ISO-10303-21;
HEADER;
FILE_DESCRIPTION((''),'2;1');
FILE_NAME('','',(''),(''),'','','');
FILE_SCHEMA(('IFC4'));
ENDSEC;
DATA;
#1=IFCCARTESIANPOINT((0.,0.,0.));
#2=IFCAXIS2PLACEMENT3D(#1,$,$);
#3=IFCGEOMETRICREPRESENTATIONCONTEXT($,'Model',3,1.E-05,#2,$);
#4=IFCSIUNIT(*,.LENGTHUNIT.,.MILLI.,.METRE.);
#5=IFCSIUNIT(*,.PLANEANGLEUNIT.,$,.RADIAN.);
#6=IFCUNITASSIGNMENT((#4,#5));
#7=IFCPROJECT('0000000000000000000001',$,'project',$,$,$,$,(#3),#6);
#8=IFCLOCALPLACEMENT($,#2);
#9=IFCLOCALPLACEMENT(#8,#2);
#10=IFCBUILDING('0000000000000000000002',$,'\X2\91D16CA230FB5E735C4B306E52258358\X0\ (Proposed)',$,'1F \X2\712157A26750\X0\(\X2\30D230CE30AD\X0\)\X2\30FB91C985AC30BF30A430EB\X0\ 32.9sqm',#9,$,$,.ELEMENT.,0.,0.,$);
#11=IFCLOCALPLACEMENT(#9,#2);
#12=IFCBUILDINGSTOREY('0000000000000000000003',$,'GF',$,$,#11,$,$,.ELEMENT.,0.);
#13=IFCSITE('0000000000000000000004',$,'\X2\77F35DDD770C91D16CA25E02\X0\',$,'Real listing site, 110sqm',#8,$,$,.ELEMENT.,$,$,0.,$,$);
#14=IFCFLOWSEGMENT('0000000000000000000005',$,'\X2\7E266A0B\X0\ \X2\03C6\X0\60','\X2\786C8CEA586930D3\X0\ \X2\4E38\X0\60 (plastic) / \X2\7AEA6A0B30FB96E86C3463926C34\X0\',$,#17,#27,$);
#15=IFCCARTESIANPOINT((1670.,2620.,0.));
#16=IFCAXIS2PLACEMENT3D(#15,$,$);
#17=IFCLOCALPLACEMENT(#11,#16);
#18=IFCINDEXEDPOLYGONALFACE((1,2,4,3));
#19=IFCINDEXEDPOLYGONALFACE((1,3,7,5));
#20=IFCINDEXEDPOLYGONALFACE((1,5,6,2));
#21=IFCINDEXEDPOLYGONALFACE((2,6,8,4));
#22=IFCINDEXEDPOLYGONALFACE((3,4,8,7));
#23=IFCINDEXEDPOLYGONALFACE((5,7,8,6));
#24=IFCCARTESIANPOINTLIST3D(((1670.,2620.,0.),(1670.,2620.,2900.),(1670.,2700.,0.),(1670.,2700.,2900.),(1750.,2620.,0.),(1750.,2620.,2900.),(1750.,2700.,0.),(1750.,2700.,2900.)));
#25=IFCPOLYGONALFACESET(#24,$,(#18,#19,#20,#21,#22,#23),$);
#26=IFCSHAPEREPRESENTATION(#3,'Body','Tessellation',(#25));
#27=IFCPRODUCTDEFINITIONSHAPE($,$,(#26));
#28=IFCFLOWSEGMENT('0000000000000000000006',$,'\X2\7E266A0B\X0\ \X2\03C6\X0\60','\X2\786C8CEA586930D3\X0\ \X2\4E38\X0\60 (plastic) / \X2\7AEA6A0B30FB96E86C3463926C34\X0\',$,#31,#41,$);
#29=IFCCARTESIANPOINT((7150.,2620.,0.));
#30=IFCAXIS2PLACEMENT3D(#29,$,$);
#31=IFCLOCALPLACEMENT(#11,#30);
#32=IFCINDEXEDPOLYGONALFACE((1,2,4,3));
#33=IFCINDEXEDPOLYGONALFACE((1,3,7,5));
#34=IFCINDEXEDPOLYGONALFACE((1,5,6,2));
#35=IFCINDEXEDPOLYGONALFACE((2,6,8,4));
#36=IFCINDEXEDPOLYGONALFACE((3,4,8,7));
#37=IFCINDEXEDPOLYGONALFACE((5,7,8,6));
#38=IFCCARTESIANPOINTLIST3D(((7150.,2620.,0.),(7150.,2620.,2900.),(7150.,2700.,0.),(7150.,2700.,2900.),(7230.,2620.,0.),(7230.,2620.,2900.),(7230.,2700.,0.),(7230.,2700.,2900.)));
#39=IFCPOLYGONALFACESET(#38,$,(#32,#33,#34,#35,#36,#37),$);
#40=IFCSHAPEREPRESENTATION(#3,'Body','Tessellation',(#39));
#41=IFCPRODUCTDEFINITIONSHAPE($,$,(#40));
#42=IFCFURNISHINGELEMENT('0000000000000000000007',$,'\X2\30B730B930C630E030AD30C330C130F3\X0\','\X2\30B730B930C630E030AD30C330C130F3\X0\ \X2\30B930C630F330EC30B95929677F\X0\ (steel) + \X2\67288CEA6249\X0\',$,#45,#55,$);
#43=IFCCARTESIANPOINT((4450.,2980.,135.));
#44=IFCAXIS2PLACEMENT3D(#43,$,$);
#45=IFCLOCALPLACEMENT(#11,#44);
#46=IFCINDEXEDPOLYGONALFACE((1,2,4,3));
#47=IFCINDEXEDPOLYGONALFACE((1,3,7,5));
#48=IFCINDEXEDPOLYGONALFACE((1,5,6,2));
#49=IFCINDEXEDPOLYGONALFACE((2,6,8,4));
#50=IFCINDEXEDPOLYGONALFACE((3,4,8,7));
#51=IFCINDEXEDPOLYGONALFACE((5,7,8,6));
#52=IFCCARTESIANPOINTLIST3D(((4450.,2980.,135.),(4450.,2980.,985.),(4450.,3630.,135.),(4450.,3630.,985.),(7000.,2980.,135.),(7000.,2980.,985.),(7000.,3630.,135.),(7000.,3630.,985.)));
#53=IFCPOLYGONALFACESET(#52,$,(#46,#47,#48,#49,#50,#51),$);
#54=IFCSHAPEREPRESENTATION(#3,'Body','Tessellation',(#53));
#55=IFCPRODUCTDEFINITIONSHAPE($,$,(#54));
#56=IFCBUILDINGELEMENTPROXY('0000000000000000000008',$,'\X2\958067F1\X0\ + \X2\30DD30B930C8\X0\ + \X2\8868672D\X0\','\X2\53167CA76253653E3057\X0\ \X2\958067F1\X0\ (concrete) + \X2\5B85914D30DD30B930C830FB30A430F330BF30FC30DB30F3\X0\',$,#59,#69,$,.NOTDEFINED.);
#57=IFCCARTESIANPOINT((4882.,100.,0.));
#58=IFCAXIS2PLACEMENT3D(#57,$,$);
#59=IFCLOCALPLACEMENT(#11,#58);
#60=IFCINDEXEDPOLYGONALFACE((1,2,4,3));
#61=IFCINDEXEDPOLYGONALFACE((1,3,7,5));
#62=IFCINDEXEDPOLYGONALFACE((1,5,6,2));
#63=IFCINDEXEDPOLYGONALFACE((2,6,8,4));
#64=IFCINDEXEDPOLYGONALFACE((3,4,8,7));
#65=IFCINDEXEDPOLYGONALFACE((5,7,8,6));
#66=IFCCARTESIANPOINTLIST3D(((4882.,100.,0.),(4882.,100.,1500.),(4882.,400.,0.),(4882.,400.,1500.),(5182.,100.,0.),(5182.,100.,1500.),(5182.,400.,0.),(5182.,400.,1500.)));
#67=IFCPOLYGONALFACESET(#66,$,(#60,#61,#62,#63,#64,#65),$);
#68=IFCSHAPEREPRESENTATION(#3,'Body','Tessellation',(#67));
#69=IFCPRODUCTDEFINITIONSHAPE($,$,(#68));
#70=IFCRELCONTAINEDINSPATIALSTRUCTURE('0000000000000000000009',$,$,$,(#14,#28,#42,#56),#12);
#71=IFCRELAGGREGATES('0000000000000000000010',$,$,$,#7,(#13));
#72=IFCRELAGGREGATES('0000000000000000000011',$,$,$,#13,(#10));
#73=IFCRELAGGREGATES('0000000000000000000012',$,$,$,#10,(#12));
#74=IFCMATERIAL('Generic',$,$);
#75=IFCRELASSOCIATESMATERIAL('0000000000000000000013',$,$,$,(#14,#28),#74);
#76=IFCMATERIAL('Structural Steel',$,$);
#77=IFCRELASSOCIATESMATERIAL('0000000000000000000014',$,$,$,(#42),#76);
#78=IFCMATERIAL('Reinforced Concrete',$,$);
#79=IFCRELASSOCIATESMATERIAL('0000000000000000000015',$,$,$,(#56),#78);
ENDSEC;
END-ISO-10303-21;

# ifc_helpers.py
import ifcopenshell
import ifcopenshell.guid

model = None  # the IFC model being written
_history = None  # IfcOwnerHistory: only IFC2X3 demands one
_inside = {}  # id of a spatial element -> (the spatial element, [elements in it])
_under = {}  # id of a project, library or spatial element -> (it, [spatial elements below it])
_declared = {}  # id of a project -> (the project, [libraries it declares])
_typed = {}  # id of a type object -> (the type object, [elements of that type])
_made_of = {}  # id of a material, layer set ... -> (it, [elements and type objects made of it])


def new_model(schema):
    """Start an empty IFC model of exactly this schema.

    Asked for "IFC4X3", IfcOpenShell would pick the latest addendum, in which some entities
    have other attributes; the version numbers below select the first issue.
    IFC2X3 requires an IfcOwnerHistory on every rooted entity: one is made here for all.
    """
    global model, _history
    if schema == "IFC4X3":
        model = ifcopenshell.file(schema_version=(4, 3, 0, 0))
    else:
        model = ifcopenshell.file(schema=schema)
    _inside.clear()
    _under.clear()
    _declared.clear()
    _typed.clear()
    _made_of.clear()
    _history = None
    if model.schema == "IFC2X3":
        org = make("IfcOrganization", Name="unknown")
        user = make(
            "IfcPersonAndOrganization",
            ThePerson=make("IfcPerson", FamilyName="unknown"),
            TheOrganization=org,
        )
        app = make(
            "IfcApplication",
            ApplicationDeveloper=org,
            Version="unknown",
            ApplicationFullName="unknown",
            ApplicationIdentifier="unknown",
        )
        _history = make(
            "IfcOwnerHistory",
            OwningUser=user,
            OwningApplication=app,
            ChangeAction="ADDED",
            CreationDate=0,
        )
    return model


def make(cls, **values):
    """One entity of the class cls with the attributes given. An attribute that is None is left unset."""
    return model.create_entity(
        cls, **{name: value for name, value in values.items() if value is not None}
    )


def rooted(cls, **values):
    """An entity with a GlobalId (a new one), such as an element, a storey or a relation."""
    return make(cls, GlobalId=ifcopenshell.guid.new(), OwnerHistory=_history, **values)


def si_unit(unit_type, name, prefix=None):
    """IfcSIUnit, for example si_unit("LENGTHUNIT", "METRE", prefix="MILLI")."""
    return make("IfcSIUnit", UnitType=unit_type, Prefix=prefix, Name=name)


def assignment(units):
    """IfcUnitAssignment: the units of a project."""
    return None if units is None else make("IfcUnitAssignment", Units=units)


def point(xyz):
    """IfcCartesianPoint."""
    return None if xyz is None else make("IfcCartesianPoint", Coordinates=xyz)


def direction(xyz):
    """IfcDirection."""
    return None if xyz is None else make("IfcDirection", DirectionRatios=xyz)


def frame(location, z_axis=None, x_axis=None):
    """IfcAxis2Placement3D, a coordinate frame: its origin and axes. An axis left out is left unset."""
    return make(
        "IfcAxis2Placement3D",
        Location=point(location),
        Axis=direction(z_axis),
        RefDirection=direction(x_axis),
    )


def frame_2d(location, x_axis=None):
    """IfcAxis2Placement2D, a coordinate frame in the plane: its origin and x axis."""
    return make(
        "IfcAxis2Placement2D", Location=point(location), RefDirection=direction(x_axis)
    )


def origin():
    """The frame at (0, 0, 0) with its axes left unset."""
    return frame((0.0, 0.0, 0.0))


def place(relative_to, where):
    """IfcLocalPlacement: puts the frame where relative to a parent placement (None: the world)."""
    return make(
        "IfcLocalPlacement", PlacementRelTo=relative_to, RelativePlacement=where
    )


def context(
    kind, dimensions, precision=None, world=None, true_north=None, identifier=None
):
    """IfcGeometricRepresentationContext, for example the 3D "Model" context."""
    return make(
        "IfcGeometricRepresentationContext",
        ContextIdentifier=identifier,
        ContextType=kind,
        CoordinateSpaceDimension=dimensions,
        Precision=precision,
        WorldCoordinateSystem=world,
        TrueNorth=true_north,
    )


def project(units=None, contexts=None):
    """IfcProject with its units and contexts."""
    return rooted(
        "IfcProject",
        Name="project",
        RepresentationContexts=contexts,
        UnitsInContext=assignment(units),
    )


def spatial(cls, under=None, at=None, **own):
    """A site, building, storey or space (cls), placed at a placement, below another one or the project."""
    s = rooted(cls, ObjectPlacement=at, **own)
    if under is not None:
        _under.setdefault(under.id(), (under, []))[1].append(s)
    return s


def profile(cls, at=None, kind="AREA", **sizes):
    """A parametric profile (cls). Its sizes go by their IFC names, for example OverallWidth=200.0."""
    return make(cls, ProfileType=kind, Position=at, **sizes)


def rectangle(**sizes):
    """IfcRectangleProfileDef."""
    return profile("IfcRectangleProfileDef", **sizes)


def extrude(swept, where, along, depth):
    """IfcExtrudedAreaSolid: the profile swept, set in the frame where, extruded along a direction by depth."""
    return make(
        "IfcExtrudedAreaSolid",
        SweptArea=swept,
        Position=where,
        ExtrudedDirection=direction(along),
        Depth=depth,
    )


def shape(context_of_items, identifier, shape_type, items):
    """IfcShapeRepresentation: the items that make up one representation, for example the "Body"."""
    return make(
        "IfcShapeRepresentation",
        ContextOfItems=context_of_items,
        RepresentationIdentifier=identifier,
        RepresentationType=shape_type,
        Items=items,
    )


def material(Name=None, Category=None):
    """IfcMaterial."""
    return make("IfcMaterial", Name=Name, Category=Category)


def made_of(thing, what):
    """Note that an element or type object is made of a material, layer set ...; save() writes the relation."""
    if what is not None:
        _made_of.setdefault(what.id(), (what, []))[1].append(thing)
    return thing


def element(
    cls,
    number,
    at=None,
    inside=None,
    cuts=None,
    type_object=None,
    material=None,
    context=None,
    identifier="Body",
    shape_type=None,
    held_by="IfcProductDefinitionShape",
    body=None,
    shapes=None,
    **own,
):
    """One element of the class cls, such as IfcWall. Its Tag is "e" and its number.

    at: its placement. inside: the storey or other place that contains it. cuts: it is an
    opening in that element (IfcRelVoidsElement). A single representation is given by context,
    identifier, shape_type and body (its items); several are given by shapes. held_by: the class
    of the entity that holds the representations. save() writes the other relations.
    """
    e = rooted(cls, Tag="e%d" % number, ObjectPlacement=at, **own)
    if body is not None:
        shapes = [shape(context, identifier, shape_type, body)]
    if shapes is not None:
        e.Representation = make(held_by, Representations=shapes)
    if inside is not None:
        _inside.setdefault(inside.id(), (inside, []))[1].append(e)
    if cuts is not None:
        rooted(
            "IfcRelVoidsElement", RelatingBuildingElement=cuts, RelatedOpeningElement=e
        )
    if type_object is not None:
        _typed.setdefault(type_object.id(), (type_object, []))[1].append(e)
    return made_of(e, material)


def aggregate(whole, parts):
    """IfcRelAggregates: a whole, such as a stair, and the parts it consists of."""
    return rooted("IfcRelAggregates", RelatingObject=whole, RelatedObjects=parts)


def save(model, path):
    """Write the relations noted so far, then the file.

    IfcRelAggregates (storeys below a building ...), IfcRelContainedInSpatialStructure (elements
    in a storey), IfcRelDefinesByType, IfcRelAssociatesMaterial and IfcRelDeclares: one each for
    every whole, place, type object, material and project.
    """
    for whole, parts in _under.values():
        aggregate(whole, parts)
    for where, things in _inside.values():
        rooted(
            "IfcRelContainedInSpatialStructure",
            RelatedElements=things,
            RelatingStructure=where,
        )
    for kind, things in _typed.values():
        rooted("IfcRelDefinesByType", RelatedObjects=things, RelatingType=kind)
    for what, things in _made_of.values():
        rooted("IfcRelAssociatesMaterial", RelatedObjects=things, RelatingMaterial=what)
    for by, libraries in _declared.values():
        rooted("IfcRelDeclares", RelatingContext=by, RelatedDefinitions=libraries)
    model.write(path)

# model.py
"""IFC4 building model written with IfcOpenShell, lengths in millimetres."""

from ifc_helpers import new_model, si_unit, frame, frame_2d, origin, place, context, project, spatial, rectangle, extrude, material, element, save


model = new_model("IFC4")

# Units and contexts
model_context = context("Model", 3, precision=1e-05, world=origin())
ifc_project = project(units=[si_unit("LENGTHUNIT", "METRE", prefix="MILLI"), si_unit("PLANEANGLEUNIT", "RADIAN")], contexts=[model_context])

# Site, building, storey
site_placement = place(None, origin())
site = spatial("IfcSite", under=ifc_project, at=site_placement, Name="石川県金沢市", ObjectType="Real listing site, 110sqm", CompositionType="ELEMENT", RefElevation=0.0)
building_placement = place(site_placement, origin())
building = spatial("IfcBuilding", under=site, at=building_placement, Name="金沢・平屋の別荘 (Proposed)", ObjectType="1F 無垢材(ヒノキ)・釉薬タイル 32.9sqm", CompositionType="ELEMENT", ElevationOfRefHeight=0.0, ElevationOfTerrain=0.0)
storey_placement = place(building_placement, origin())
storey = spatial("IfcBuildingStorey", under=building, at=storey_placement, Name="GF", CompositionType="ELEMENT", Elevation=0.0)

# Shared definitions
ifc_material_1 = material(Name="Reinforced Concrete")

# Shared definitions
ifc_material_2 = material(Name="Structural Steel")

# Shared definitions
ifc_material_3 = material(Name="Generic")

# Flow segments
flow_segment_1_placement = place(storey_placement, frame((1670.0, 2620.0, 0.0)))
element("IfcFlowSegment", 1, at=flow_segment_1_placement, inside=storey, material=ifc_material_3, Name="縦樋 φ60", Description="硬質塩ビ 丸60 (plastic) / 竪樋・雨水排水", context=model_context, shape_type="SweptSolid", body=[
    extrude(rectangle(XDim=80.0, YDim=80.0, at=frame_2d((40.0, 40.0))), frame((1670.0, 2620.0, 0.0)), (0.0, 0.0, 1.0), 2900.0),
])
flow_segment_2_placement = place(storey_placement, frame((7150.0, 2620.0, 0.0)))
element("IfcFlowSegment", 2, at=flow_segment_2_placement, inside=storey, material=ifc_material_3, Name="縦樋 φ60", Description="硬質塩ビ 丸60 (plastic) / 竪樋・雨水排水", context=model_context, shape_type="SweptSolid", body=[
    extrude(rectangle(XDim=80.0, YDim=80.0, at=frame_2d((40.0, 40.0))), frame((7150.0, 2620.0, 0.0)), (0.0, 0.0, 1.0), 2900.0),
])

# Furnishing element
furnishing_placement = place(storey_placement, frame((4450.0, 2980.0, 135.0)))
element("IfcFurnishingElement", 3, at=furnishing_placement, inside=storey, material=ifc_material_2, Name="システムキッチン", Description="システムキッチン ステンレス天板 (steel) + 木質扉", context=model_context, shape_type="SweptSolid", body=[
    extrude(rectangle(XDim=2550.0, YDim=650.0, at=frame_2d((1275.0, 325.0))), frame((4450.0, 2980.0, 135.0)), (0.0, 0.0, 1.0), 850.0),
])

# Building element proxy
proxy_placement = place(storey_placement, frame((4882.0, 100.0, 0.0)))
element("IfcBuildingElementProxy", 4, at=proxy_placement, inside=storey, material=ifc_material_1, Name="門柱 + ポスト + 表札", Description="化粧打放し 門柱 (concrete) + 宅配ポスト・インターホン", PredefinedType="NOTDEFINED", context=model_context, shape_type="SweptSolid", body=[
    extrude(rectangle(XDim=300.0, YDim=300.0, at=frame_2d((150.0, 150.0))), frame((4882.0, 100.0, 0.0)), (0.0, 0.0, 1.0), 1500.0),
])

save(model, "model.ifc")
